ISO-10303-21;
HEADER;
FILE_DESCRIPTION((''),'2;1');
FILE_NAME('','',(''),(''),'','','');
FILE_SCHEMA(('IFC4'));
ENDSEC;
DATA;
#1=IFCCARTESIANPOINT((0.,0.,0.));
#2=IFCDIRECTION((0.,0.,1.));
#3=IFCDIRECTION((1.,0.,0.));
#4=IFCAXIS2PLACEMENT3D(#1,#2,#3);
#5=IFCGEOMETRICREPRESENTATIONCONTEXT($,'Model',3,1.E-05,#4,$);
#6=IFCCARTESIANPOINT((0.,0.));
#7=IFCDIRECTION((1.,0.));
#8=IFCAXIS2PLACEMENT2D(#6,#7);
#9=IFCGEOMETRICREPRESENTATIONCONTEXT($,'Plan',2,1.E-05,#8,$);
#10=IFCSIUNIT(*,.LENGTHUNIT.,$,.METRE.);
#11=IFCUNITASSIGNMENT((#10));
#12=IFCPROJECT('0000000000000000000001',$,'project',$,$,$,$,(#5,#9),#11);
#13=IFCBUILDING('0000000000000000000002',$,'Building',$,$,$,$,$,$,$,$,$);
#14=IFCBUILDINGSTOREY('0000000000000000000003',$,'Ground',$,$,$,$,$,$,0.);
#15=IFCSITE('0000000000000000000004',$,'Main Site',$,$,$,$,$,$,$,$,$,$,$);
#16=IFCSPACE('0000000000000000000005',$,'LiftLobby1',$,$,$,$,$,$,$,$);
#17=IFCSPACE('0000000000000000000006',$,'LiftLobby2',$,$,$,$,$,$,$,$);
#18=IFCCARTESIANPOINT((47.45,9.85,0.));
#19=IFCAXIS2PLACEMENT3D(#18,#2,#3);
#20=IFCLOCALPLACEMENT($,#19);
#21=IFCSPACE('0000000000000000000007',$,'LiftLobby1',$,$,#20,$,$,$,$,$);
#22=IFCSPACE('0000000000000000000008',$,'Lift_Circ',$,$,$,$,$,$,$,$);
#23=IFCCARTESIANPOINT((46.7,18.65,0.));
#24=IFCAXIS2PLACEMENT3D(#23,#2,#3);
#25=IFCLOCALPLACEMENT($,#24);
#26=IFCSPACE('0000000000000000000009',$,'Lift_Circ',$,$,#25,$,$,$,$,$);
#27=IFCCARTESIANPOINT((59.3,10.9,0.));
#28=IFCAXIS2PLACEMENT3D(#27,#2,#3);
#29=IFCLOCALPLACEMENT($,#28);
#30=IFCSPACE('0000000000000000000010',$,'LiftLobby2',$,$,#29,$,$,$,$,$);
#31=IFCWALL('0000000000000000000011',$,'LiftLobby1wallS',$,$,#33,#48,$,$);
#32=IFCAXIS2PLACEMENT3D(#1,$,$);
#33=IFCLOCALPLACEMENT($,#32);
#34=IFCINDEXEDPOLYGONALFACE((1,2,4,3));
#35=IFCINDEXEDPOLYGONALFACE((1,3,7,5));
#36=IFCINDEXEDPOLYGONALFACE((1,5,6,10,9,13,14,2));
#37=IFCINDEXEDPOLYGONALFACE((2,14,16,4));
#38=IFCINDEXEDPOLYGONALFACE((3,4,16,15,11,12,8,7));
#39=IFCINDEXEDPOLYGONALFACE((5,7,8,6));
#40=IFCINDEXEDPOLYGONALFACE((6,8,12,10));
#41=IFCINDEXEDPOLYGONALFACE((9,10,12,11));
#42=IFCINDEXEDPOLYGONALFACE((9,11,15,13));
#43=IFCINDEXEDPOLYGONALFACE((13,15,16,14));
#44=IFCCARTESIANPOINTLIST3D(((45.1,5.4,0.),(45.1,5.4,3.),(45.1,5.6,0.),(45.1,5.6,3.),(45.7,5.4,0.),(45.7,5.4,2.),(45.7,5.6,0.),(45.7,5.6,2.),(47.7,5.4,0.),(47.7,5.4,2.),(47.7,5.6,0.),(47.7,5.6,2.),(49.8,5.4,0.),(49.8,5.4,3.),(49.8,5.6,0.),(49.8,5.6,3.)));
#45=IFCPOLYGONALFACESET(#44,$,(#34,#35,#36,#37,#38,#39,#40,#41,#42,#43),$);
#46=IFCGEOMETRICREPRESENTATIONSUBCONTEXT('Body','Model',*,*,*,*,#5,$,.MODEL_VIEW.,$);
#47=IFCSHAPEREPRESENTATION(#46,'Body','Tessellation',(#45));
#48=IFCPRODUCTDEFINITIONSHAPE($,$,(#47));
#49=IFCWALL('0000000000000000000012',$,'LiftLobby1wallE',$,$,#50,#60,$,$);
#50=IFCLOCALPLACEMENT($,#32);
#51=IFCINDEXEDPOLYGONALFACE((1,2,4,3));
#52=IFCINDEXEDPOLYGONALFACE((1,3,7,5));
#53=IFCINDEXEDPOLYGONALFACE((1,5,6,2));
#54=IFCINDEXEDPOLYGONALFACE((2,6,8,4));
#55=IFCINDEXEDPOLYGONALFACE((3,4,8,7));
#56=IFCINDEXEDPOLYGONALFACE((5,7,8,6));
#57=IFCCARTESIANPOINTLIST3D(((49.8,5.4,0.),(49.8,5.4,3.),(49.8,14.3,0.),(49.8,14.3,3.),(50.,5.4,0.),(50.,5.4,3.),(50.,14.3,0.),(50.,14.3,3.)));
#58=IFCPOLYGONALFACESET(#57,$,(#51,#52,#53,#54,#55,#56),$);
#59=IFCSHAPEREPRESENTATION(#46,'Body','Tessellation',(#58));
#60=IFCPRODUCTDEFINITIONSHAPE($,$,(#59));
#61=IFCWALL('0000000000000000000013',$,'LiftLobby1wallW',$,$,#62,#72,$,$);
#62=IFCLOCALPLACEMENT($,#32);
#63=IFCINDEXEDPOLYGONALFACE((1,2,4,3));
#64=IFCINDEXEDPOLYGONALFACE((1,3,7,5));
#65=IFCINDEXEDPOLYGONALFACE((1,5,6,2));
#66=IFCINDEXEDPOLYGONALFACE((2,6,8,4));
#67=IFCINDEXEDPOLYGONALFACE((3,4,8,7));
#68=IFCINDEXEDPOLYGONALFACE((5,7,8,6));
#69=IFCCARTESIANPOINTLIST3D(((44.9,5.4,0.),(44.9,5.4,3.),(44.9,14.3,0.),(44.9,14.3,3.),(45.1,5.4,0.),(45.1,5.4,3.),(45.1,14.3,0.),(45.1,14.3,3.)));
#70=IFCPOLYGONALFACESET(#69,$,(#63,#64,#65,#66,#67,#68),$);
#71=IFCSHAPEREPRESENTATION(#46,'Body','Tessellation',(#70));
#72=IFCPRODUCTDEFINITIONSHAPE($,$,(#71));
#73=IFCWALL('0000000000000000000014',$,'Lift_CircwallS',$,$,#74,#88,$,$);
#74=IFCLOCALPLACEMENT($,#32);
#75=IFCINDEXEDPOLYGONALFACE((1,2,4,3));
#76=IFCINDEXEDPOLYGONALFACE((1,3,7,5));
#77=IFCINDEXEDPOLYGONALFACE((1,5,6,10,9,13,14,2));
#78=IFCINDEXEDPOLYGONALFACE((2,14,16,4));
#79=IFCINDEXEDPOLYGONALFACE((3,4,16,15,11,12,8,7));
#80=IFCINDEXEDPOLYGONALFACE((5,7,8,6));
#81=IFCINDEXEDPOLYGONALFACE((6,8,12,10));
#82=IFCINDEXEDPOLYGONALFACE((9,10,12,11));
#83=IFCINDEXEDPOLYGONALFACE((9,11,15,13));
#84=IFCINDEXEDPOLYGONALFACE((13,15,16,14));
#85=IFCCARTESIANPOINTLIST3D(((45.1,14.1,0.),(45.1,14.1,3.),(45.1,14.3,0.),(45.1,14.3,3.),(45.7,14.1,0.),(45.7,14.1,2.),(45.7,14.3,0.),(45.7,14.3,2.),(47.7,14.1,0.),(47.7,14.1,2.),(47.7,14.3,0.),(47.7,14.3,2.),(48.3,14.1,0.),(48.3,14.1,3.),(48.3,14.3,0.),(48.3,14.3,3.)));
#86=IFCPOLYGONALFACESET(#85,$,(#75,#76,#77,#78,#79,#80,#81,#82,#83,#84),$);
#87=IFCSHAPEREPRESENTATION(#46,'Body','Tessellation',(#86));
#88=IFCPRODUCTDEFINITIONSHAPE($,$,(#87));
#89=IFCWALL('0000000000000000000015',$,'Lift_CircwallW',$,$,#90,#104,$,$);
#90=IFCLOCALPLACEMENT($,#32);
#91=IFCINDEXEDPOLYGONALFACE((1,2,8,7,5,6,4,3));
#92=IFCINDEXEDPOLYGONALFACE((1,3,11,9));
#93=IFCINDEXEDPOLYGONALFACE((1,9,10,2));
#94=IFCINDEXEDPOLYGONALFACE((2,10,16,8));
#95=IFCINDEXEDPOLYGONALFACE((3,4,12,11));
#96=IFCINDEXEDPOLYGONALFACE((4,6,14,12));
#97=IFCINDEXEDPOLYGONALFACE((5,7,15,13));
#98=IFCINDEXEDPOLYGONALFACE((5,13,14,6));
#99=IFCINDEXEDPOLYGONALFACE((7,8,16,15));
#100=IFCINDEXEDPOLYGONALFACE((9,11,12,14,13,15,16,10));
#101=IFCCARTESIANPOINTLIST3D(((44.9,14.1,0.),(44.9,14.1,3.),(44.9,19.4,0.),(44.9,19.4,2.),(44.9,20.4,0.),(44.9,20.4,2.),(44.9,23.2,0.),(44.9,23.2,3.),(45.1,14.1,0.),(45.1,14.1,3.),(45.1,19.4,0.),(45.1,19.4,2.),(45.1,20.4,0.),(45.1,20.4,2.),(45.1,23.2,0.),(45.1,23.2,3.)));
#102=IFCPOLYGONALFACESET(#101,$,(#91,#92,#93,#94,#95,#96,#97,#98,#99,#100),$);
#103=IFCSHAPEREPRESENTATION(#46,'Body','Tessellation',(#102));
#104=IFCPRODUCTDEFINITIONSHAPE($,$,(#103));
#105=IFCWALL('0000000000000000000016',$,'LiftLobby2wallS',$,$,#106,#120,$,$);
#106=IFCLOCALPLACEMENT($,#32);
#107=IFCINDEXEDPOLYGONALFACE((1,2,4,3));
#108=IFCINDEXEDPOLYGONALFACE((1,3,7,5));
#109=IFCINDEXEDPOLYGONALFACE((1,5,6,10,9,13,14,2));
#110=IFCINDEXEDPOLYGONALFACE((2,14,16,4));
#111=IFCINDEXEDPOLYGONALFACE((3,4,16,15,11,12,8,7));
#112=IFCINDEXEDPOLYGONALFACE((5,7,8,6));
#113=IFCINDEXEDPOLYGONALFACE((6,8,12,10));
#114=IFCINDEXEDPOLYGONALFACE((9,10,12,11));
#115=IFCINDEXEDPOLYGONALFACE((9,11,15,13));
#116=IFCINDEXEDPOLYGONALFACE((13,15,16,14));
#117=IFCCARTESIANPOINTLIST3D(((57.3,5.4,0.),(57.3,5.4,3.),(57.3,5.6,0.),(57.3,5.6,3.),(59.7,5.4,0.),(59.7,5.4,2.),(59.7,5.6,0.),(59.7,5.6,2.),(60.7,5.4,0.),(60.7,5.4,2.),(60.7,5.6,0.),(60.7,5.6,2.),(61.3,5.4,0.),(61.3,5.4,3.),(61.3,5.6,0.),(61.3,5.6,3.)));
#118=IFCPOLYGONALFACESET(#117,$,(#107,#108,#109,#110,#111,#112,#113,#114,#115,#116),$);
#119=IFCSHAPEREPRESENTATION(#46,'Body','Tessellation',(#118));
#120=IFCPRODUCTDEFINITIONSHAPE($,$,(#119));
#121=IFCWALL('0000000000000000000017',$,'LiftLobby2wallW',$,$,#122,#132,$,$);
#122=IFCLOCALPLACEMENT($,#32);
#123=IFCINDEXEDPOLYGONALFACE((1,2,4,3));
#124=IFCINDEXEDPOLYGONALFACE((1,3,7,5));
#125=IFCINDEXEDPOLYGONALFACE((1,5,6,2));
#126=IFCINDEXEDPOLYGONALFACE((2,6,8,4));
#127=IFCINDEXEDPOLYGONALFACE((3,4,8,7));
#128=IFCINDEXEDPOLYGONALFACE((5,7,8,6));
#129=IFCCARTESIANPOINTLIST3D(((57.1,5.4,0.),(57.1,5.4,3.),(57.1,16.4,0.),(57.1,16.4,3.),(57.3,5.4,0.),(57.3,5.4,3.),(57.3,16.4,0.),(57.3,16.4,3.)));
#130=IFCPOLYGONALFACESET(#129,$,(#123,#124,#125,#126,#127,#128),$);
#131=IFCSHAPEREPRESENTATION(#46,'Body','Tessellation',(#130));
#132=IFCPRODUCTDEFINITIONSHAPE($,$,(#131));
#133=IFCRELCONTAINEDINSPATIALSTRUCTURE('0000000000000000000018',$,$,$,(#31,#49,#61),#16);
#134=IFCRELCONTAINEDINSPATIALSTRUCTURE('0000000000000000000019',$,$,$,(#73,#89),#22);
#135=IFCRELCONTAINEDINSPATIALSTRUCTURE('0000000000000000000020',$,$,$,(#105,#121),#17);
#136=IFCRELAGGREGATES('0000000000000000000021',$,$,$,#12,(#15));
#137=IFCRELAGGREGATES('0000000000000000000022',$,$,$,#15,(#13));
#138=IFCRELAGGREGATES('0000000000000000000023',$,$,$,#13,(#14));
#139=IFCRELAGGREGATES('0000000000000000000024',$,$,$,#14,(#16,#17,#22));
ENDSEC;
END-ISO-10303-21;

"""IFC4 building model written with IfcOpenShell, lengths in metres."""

from ifc_helpers import new_model, si_unit, frame, origin_with_axes, origin_2d_with_axis, place, context, subcontext, project, spatial, indexed_curve, outline, extrude, element, save


model = new_model("IFC4")

# Units and contexts
model_context = context("Model", 3, precision=1e-05, world=origin_with_axes())
plan_context = context("Plan", 2, precision=1e-05, world=origin_2d_with_axis())
body_context = subcontext(model_context, "Body", "Model", "MODEL_VIEW")
ifc_project = project(units=[si_unit("LENGTHUNIT", "METRE")], contexts=[model_context, plan_context])

# Site, building, storey
site = spatial("IfcSite", under=ifc_project, Name="Main Site")
building = spatial("IfcBuilding", under=site, Name="Building")
storey = spatial("IfcBuildingStorey", under=building, Name="Ground", Elevation=0.0)

# Shared definitions
space_1 = spatial("IfcSpace", under=storey, Name="LiftLobby1")

# Shared definitions
space_2 = spatial("IfcSpace", under=storey, Name="LiftLobby2")

# Shared definitions
space_3_placement = place(None, frame((47.45, 9.85, 0.0), z_axis=(0.0, 0.0, 1.0), x_axis=(1.0, 0.0, 0.0)))
space_3 = spatial("IfcSpace", at=space_3_placement, Name="LiftLobby1")

# Wall, opening
wall_1_placement = place(None, frame((45.1, 5.4, 0.0), z_axis=(0.0, 0.0, 1.0), x_axis=(1.0, 0.0, 0.0)))
wall_1 = element("IfcWall", 1, at=wall_1_placement, inside=space_1, Name="LiftLobby1wallS", context=body_context, shape_type="SweptSolid", body=[
    extrude(outline(indexed_curve([(0.0, 0.0), (0.0, 0.2), (4.7, 0.2), (4.7, 0.0), (0.0, 0.0)], self_intersect=False)), origin_with_axes(), (0.0, 0.0, 1.0), 3.0),
])
opening_1_placement = place(wall_1_placement, frame((0.6, 0.0, 0.0), z_axis=(0.0, 0.0, 1.0), x_axis=(1.0, 0.0, 0.0)))
element("IfcOpeningElement", 2, at=opening_1_placement, inside=space_3, cuts=wall_1, context=body_context, shape_type="SweptSolid", body=[
    extrude(outline(indexed_curve([(0.0, 0.0), (0.0, 0.4), (2.0, 0.4), (2.0, 0.0), (0.0, 0.0)], self_intersect=False)), origin_with_axes(), (0.0, 0.0, 1.0), 2.0),
])

# Walls
for number, where, z_axis, x_axis, name in (
    (3, (50.0, 5.4, 0.0), (0.0, 0.0, 1.0), (0.0, 1.0, 0.0), "LiftLobby1wallE"),
    (4, (45.1, 5.4, 0.0), (0.0, 0.0, 1.0), (0.0, 1.0, 0.0), "LiftLobby1wallW"),
):
    element("IfcWall", number, at=place(None, frame(where, z_axis=z_axis, x_axis=x_axis)), inside=space_1, Name=name, context=body_context, shape_type="SweptSolid", body=[
        extrude(outline(indexed_curve([(0.0, 0.0), (0.0, 0.2), (8.9, 0.2), (8.9, 0.0), (0.0, 0.0)], self_intersect=False)), origin_with_axes(), (0.0, 0.0, 1.0), 3.0),
    ])

# Shared definitions
space_4 = spatial("IfcSpace", under=storey, Name="Lift_Circ")

# Wall
wall_2_placement = place(None, frame((45.1, 14.1, 0.0), z_axis=(0.0, 0.0, 1.0), x_axis=(1.0, 0.0, 0.0)))
wall_2 = element("IfcWall", 5, at=wall_2_placement, inside=space_4, Name="Lift_CircwallS", context=body_context, shape_type="SweptSolid", body=[
    extrude(outline(indexed_curve([(0.0, 0.0), (0.0, 0.2), (3.2, 0.2), (3.2, 0.0), (0.0, 0.0)], self_intersect=False)), origin_with_axes(), (0.0, 0.0, 1.0), 3.0),
])

# Shared definitions
space_5_placement = place(None, frame((46.7, 18.65, 0.0), z_axis=(0.0, 0.0, 1.0), x_axis=(1.0, 0.0, 0.0)))
space_5 = spatial("IfcSpace", at=space_5_placement, Name="Lift_Circ")

# Opening
opening_2_placement = place(wall_2_placement, frame((0.6, 0.0, 0.0), z_axis=(0.0, 0.0, 1.0), x_axis=(1.0, 0.0, 0.0)))
element("IfcOpeningElement", 6, at=opening_2_placement, inside=space_5, cuts=wall_2, context=body_context, shape_type="SweptSolid", body=[
    extrude(outline(indexed_curve([(0.0, 0.0), (0.0, 0.4), (2.0, 0.4), (2.0, 0.0), (0.0, 0.0)], self_intersect=False)), origin_with_axes(), (0.0, 0.0, 1.0), 2.0),
])

# Wall, opening
wall_3_placement = place(None, frame((45.1, 14.1, 0.0), z_axis=(0.0, 0.0, 1.0), x_axis=(0.0, 1.0, 0.0)))
wall_3 = element("IfcWall", 7, at=wall_3_placement, inside=space_4, Name="Lift_CircwallW", context=body_context, shape_type="SweptSolid", body=[
    extrude(outline(indexed_curve([(0.0, 0.0), (0.0, 0.2), (9.1, 0.2), (9.1, 0.0), (0.0, 0.0)], self_intersect=False)), origin_with_axes(), (0.0, 0.0, 1.0), 3.0),
])
opening_3_placement = place(wall_3_placement, frame((5.3, 0.0, 0.0), z_axis=(0.0, 0.0, 1.0), x_axis=(1.0, 0.0, 0.0)))
element("IfcOpeningElement", 8, at=opening_3_placement, inside=space_5, cuts=wall_3, context=body_context, shape_type="SweptSolid", body=[
    extrude(outline(indexed_curve([(0.0, 0.0), (0.0, 0.4), (1.0, 0.4), (1.0, 0.0), (0.0, 0.0)], self_intersect=False)), origin_with_axes(), (0.0, 0.0, 1.0), 2.0),
])

# Wall
wall_4_placement = place(None, frame((57.3, 5.4, 0.0), z_axis=(0.0, 0.0, 1.0), x_axis=(1.0, 0.0, 0.0)))
wall_4 = element("IfcWall", 9, at=wall_4_placement, inside=space_2, Name="LiftLobby2wallS", context=body_context, shape_type="SweptSolid", body=[
    extrude(outline(indexed_curve([(0.0, 0.0), (0.0, 0.2), (4.0, 0.2), (4.0, 0.0), (0.0, 0.0)], self_intersect=False)), origin_with_axes(), (0.0, 0.0, 1.0), 3.0),
])

# Shared definitions
space_6_placement = place(None, frame((59.3, 10.9, 0.0), z_axis=(0.0, 0.0, 1.0), x_axis=(1.0, 0.0, 0.0)))
space_6 = spatial("IfcSpace", at=space_6_placement, Name="LiftLobby2")

# Opening
opening_4_placement = place(wall_4_placement, frame((2.4, 0.0, 0.0), z_axis=(0.0, 0.0, 1.0), x_axis=(1.0, 0.0, 0.0)))
element("IfcOpeningElement", 10, at=opening_4_placement, inside=space_6, cuts=wall_4, context=body_context, shape_type="SweptSolid", body=[
    extrude(outline(indexed_curve([(0.0, 0.0), (0.0, 0.4), (1.0, 0.4), (1.0, 0.0), (0.0, 0.0)], self_intersect=False)), origin_with_axes(), (0.0, 0.0, 1.0), 2.0),
])

# Wall
wall_5_placement = place(None, frame((57.3, 5.4, 0.0), z_axis=(0.0, 0.0, 1.0), x_axis=(0.0, 1.0, 0.0)))
element("IfcWall", 11, at=wall_5_placement, inside=space_2, Name="LiftLobby2wallW", context=body_context, shape_type="SweptSolid", body=[
    extrude(outline(indexed_curve([(0.0, 0.0), (0.0, 0.2), (11.0, 0.2), (11.0, 0.0), (0.0, 0.0)], self_intersect=False)), origin_with_axes(), (0.0, 0.0, 1.0), 3.0),
])

save(model, "model.ifc")
